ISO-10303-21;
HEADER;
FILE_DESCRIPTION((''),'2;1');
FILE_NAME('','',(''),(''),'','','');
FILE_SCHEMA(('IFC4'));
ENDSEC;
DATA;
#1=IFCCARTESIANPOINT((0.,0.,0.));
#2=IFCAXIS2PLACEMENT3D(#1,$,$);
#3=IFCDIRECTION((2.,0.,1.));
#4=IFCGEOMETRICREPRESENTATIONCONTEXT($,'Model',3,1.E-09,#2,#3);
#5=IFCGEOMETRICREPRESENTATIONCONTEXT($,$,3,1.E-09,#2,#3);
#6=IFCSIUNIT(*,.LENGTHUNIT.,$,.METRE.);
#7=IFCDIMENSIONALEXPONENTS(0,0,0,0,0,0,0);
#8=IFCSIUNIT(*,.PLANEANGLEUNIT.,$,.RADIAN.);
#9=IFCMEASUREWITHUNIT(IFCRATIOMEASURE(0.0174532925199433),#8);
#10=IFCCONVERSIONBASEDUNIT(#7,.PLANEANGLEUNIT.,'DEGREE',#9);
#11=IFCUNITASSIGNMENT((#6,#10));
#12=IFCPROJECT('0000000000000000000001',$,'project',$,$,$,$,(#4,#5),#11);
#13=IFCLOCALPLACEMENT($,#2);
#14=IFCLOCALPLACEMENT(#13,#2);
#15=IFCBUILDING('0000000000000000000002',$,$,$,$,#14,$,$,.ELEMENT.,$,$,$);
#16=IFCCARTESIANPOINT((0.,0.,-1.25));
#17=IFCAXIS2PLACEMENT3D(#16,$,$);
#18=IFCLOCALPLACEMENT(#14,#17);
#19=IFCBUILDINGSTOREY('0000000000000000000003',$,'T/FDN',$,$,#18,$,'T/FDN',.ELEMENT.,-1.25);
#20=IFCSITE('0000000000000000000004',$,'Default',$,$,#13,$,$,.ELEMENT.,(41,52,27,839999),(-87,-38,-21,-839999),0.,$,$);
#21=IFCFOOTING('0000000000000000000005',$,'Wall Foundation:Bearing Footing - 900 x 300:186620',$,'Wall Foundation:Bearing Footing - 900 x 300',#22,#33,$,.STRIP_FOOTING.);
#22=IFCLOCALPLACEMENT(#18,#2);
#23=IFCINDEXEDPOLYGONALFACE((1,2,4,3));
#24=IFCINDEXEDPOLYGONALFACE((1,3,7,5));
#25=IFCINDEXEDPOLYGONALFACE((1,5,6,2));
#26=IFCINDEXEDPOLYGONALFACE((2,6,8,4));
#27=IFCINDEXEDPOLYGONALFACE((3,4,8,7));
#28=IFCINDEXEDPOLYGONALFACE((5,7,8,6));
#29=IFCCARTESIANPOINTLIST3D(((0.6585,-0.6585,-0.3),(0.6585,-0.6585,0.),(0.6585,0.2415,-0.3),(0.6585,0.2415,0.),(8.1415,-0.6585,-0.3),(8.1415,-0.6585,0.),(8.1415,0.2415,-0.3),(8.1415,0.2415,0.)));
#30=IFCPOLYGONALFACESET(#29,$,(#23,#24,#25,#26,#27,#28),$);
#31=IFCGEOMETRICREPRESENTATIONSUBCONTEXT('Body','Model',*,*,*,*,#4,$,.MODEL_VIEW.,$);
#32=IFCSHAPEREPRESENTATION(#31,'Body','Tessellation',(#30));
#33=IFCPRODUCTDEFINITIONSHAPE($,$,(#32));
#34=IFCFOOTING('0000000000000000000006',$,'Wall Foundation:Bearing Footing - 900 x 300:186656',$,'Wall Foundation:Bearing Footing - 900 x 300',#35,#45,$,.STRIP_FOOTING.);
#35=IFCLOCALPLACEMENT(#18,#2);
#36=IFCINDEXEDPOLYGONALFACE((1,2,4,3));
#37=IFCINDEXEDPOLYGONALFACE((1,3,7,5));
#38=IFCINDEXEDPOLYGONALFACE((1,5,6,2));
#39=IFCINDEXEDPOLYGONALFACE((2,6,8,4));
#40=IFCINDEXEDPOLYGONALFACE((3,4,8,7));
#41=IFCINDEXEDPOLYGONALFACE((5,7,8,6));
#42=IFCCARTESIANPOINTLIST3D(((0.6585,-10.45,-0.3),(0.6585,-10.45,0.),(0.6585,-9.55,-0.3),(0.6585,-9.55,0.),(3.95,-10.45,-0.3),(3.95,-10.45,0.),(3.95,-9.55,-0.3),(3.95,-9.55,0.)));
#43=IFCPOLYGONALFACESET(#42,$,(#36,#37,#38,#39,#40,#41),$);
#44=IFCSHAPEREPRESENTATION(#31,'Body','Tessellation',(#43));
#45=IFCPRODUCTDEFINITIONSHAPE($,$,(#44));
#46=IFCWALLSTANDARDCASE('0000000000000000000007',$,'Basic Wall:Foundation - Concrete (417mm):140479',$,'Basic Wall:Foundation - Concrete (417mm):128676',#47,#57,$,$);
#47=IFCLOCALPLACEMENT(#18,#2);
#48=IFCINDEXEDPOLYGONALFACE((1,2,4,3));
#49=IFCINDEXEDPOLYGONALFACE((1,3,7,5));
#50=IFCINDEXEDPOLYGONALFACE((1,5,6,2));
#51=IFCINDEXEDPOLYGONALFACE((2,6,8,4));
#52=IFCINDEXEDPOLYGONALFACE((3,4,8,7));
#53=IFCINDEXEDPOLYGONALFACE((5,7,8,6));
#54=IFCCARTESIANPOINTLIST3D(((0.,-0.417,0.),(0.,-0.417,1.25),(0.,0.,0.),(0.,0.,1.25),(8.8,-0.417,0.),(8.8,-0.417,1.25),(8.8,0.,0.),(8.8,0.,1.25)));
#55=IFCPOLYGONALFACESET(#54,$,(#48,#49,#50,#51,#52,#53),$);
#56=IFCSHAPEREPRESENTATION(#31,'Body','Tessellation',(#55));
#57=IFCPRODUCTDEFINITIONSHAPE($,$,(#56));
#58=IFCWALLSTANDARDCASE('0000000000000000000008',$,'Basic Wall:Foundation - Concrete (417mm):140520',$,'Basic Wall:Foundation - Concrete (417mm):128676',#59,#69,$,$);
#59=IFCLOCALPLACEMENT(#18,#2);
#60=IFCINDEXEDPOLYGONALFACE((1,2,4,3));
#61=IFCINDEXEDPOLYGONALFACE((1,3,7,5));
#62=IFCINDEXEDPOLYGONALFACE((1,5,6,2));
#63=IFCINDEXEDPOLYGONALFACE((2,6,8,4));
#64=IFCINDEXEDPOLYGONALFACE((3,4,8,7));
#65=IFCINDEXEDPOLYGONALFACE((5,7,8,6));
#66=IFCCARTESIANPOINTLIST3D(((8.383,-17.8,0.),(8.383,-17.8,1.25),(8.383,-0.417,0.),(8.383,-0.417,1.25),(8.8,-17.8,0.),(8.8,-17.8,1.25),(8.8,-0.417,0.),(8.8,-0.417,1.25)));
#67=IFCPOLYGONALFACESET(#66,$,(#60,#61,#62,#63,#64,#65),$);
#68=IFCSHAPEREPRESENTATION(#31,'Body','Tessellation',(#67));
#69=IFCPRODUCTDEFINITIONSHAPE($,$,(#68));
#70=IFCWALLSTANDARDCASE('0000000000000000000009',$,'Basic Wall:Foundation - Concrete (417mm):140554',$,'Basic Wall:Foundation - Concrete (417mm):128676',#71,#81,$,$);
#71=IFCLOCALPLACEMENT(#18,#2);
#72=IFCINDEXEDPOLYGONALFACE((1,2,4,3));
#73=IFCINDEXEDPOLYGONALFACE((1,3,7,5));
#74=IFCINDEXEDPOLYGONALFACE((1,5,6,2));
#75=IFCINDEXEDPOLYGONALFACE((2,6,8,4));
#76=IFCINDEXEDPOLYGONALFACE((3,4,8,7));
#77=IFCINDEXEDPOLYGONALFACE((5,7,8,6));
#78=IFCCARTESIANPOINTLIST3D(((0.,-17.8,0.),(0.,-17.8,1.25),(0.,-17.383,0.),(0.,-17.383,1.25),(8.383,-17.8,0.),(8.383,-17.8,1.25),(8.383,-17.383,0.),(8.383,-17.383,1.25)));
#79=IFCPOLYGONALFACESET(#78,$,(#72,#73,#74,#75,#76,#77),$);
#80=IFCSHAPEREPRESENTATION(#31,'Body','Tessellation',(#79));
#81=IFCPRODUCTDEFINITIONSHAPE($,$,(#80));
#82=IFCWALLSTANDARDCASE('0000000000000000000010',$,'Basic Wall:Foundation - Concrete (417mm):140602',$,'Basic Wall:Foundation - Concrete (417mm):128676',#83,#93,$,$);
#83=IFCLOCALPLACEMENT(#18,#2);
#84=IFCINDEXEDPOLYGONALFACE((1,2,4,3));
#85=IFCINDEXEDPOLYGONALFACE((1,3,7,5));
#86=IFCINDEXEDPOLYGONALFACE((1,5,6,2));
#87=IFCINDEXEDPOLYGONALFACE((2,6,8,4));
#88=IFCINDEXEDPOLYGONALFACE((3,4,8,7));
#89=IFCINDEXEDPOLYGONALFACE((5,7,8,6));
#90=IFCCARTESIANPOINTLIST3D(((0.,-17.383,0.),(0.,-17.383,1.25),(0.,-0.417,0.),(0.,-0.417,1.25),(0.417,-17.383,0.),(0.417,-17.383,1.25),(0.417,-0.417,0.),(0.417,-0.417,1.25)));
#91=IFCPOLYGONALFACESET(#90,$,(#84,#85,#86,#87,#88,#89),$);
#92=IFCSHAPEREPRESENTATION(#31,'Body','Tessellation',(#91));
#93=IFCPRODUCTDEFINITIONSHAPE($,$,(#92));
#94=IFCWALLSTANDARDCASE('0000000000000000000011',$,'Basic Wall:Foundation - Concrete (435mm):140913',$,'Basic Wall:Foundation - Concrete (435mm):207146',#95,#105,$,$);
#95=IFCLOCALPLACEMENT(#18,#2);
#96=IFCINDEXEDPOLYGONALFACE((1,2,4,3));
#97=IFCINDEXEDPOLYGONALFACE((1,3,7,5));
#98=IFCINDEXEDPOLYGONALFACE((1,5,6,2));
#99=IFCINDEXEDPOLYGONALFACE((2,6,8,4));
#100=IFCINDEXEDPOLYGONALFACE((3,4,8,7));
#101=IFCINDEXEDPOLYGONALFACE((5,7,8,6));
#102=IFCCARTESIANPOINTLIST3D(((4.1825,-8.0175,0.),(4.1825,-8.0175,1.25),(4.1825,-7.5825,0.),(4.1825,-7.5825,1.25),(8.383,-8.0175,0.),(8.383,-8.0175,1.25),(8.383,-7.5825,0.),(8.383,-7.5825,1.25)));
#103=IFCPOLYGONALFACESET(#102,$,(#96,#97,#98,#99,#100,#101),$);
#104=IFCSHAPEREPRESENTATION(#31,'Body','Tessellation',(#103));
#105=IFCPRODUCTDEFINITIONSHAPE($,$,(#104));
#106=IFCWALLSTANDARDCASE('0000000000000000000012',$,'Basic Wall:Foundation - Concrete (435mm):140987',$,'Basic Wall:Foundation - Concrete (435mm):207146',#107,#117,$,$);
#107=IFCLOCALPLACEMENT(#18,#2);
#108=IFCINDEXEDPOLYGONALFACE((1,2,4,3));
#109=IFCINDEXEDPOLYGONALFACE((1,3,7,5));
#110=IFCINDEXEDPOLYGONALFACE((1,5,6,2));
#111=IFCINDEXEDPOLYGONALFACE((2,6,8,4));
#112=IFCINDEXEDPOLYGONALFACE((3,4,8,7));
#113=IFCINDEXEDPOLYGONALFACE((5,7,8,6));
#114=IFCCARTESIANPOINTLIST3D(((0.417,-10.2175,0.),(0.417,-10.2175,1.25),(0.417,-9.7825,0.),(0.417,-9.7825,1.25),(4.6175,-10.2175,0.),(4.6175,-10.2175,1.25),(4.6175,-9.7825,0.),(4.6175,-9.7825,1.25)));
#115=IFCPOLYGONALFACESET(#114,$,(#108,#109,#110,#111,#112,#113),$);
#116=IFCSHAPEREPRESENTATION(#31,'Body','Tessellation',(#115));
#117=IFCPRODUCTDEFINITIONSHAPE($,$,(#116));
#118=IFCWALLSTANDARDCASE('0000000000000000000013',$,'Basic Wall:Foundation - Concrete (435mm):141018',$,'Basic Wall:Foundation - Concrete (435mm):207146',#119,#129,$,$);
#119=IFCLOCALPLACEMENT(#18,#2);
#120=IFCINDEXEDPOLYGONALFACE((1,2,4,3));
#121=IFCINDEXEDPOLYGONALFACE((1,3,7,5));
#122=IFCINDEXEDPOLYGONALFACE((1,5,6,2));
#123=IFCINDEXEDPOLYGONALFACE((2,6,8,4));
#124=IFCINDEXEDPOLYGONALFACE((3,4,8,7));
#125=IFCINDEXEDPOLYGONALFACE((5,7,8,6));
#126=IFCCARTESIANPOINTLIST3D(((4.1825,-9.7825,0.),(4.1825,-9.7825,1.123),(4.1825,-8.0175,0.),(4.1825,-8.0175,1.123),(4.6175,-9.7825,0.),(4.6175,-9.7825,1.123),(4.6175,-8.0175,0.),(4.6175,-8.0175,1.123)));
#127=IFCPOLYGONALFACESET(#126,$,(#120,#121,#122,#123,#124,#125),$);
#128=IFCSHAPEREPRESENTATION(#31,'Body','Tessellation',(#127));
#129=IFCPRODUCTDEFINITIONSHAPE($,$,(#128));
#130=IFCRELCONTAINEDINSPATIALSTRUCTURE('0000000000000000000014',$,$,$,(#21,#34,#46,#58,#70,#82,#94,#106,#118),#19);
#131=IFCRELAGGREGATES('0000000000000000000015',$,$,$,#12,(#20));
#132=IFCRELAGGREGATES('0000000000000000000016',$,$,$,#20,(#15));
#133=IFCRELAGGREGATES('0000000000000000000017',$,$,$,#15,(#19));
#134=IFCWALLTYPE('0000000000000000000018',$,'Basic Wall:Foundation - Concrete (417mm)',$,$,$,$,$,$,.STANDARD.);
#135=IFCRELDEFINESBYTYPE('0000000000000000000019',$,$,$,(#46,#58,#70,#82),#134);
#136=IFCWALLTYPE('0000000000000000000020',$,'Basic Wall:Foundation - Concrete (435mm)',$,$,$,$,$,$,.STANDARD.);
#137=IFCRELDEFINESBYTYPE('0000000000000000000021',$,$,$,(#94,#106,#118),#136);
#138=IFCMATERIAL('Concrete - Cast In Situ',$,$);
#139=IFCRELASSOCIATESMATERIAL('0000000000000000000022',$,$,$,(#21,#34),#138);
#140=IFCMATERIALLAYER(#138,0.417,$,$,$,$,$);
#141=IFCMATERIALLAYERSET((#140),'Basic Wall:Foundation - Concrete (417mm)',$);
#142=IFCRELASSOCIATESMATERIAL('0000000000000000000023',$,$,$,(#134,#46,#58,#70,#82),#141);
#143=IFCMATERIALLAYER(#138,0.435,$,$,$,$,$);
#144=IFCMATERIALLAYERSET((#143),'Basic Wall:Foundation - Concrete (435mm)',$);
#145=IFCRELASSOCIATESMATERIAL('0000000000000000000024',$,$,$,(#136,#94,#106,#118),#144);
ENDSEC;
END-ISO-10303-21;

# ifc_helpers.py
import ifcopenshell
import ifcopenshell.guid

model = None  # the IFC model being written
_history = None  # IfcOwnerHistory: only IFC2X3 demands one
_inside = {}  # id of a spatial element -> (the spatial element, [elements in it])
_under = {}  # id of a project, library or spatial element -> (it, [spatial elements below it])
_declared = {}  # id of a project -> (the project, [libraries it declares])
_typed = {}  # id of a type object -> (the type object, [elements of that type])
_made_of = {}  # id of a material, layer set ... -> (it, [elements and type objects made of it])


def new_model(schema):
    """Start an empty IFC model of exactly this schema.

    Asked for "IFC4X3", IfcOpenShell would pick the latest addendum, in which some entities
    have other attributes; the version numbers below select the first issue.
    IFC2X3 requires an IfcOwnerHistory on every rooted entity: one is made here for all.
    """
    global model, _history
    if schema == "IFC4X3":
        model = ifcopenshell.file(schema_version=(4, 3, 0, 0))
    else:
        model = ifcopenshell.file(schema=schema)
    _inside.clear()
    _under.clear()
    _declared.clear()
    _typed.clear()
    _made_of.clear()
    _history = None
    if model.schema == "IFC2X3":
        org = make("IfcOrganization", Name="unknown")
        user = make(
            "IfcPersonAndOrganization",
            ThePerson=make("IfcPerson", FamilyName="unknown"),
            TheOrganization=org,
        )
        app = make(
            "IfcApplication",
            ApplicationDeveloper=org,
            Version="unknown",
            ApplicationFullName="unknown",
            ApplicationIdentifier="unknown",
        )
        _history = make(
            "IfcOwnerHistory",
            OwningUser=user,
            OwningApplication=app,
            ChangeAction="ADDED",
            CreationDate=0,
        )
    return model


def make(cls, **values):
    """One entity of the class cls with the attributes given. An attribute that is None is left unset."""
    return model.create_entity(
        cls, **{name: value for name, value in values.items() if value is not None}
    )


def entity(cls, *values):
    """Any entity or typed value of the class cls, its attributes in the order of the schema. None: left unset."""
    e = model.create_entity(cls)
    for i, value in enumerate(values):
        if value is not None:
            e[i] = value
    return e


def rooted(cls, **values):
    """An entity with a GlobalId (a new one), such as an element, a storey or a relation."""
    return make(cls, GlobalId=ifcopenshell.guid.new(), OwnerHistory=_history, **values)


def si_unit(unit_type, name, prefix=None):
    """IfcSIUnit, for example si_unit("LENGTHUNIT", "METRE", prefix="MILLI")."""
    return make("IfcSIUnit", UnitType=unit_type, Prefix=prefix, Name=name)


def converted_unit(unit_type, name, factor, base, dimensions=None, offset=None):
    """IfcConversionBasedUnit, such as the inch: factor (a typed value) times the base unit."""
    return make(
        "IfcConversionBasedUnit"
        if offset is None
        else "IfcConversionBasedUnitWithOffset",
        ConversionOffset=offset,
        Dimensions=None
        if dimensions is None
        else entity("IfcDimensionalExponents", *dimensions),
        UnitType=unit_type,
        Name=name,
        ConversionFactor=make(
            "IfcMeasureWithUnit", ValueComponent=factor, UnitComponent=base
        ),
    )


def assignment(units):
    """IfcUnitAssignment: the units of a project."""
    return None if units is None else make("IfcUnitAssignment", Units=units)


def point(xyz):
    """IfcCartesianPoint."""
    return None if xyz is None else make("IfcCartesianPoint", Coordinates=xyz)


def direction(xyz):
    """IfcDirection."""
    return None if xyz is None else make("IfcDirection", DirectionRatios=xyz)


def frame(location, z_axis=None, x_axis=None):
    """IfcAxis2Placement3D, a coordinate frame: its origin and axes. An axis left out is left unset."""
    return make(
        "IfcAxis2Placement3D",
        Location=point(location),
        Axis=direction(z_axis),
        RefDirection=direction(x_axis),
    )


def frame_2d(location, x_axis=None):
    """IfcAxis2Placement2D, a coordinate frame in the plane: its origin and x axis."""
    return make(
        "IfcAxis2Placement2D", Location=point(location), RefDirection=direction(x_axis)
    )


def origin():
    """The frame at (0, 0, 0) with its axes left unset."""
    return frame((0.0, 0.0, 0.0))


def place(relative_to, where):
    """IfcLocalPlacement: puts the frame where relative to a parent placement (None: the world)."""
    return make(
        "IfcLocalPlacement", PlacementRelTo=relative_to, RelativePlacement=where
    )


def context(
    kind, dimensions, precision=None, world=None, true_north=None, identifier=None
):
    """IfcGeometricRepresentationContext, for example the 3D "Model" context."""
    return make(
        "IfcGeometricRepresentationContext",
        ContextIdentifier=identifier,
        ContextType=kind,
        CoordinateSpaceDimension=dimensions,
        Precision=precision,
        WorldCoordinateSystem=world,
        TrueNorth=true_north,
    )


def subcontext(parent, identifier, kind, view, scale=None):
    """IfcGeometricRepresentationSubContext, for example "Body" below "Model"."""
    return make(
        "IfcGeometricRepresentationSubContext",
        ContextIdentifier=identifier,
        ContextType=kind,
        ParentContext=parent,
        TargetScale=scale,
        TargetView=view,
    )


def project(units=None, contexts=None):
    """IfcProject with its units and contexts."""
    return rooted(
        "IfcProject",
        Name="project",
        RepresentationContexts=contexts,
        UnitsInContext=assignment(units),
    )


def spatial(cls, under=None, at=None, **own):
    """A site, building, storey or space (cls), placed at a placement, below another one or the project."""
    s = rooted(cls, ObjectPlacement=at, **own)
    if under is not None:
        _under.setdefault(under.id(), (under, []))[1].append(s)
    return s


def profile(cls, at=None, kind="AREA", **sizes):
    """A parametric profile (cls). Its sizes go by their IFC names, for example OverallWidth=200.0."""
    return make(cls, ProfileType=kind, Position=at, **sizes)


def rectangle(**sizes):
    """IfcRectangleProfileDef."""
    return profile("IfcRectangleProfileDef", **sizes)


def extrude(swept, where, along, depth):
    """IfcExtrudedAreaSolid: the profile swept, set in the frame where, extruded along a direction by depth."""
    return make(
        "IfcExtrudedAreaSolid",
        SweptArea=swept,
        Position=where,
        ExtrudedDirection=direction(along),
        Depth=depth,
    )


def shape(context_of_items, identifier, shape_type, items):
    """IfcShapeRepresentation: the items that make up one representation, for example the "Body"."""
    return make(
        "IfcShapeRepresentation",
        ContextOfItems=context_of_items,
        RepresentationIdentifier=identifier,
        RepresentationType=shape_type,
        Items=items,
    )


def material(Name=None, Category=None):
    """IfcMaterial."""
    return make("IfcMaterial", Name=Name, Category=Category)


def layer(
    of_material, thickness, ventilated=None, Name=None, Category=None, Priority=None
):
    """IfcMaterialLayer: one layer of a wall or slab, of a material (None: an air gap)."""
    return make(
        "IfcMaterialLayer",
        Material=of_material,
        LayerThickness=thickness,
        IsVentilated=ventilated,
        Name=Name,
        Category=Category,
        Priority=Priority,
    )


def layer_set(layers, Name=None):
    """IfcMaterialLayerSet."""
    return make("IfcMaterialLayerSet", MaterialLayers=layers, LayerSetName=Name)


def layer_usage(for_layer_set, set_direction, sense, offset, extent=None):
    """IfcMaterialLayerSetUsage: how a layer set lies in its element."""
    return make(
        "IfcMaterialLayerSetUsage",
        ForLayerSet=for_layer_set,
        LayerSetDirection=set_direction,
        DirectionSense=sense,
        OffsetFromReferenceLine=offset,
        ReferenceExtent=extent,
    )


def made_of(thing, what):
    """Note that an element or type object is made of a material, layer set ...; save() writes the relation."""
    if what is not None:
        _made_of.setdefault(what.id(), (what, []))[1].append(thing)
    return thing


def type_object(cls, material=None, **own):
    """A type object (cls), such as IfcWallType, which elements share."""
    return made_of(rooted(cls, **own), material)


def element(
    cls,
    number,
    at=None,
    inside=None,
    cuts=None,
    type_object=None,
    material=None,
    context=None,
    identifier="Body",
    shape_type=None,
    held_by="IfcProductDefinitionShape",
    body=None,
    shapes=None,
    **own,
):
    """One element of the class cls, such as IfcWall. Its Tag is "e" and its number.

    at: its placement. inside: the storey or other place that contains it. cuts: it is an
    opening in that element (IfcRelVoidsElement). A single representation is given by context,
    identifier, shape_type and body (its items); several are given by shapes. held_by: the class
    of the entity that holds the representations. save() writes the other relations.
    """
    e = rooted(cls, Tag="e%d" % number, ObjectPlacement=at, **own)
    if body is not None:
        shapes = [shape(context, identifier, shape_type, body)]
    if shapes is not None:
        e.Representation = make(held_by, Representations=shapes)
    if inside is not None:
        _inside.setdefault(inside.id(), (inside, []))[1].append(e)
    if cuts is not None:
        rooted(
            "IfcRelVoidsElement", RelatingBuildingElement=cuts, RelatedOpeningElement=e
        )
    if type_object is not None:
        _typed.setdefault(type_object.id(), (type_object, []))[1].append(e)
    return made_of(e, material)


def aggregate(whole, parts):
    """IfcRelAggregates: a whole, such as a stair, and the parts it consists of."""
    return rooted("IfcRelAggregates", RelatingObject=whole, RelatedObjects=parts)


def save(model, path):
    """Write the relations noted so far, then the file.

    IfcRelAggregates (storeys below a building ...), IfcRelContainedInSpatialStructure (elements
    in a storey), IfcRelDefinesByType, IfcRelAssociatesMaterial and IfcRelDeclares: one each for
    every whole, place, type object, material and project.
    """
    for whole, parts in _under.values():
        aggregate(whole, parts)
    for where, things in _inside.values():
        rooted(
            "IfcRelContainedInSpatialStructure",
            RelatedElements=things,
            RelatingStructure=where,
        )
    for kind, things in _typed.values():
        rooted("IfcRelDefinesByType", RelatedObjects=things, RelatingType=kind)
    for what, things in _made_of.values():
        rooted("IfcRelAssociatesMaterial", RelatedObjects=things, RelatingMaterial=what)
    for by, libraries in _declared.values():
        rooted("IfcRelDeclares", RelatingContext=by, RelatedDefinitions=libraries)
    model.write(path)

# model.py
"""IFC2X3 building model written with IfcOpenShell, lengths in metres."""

from ifc_helpers import new_model, entity, si_unit, converted_unit, direction, frame, frame_2d, origin, place, context, subcontext, project, spatial, rectangle, extrude, material, layer, layer_set, layer_usage, type_object, element, save


model = new_model("IFC2X3")

# Units and contexts
model_context = context("Model", 3, precision=1e-09, world=origin(), true_north=direction((2.0, 0.0, 1.0)))
context_of_model = context(None, 3, precision=1e-09, world=origin(), true_north=direction((2.0, 0.0, 1.0)))
body_context = subcontext(model_context, "Body", "Model", "MODEL_VIEW")
ifc_project = project(units=[si_unit("LENGTHUNIT", "METRE"), converted_unit("PLANEANGLEUNIT", "DEGREE", entity("IfcRatioMeasure", 0.0174532925199433), si_unit("PLANEANGLEUNIT", "RADIAN"), dimensions=[0, 0, 0, 0, 0, 0, 0])], contexts=[model_context, context_of_model])

# Site, building, storey
site_placement = place(None, origin())
site = spatial("IfcSite", under=ifc_project, at=site_placement, Name="Default", CompositionType="ELEMENT", RefLatitude=(41, 52, 27, 839999), RefLongitude=(-87, -38, -21, -839999), RefElevation=0.0)
building_placement = place(site_placement, origin())
building = spatial("IfcBuilding", under=site, at=building_placement, CompositionType="ELEMENT")
storey_placement = place(building_placement, frame((0.0, 0.0, -1.25)))
storey = spatial("IfcBuildingStorey", under=building, at=storey_placement, Name="T/FDN", LongName="T/FDN", CompositionType="ELEMENT", Elevation=-1.25)

# Footings
ifc_material = material(Name="Concrete - Cast In Situ")
footing_1_placement = place(storey_placement, origin())
element("IfcFooting", 1, at=footing_1_placement, inside=storey, material=ifc_material, Name="Wall Foundation:Bearing Footing - 900 x 300:186620", ObjectType="Wall Foundation:Bearing Footing - 900 x 300", PredefinedType="STRIP_FOOTING", context=body_context, shape_type="SweptSolid", body=[
    extrude(rectangle(XDim=7.483, YDim=0.9, at=frame_2d((0.0, 0.0), x_axis=(1.0, 0.0))), frame((4.4, -0.2085, -0.3), z_axis=(0.0, 0.0, 1.0), x_axis=(-1.0, 0.0, 0.0)), (0.0, 0.0, 1.0), 0.3),
])
footing_2_placement = place(storey_placement, origin())
element("IfcFooting", 2, at=footing_2_placement, inside=storey, material=ifc_material, Name="Wall Foundation:Bearing Footing - 900 x 300:186656", ObjectType="Wall Foundation:Bearing Footing - 900 x 300", PredefinedType="STRIP_FOOTING", context=body_context, shape_type="SweptSolid", body=[
    extrude(rectangle(XDim=3.2915, YDim=0.9, at=frame_2d((0.0, 0.0), x_axis=(1.0, 0.0))), frame((2.3043, -10.0, -0.3)), (0.0, 0.0, 1.0), 0.3),
])

# Walls
ifc_layer_1 = layer(ifc_material, 0.417)
ifc_layer_set_1 = layer_set([ifc_layer_1], Name="Basic Wall:Foundation - Concrete (417mm)")
ifc_layer_usage_1 = layer_usage(ifc_layer_set_1, "AXIS2", "NEGATIVE", 0.2085)
wall_type_1 = type_object("IfcWallType", Name="Basic Wall:Foundation - Concrete (417mm)", PredefinedType="STANDARD", material=ifc_layer_set_1)
wall_1_placement = place(storey_placement, frame((0.0, -0.2085, 0.0)))
element("IfcWallStandardCase", 3, at=wall_1_placement, inside=storey, type_object=wall_type_1, material=ifc_layer_usage_1, Name="Basic Wall:Foundation - Concrete (417mm):140479", ObjectType="Basic Wall:Foundation - Concrete (417mm):128676", context=body_context, shape_type="SweptSolid", body=[
    extrude(rectangle(XDim=8.8, YDim=0.417, at=frame_2d((4.4, 0.0), x_axis=(-1.0, 0.0))), origin(), (0.0, 0.0, 1.0), 1.25),
])
ifc_layer_usage_2 = layer_usage(ifc_layer_set_1, "AXIS2", "NEGATIVE", 0.2085)
wall_2_placement = place(storey_placement, frame((8.5915, -0.417, 0.0), z_axis=(0.0, 0.0, 1.0), x_axis=(0.0, -1.0, 0.0)))
element("IfcWallStandardCase", 4, at=wall_2_placement, inside=storey, type_object=wall_type_1, material=ifc_layer_usage_2, Name="Basic Wall:Foundation - Concrete (417mm):140520", ObjectType="Basic Wall:Foundation - Concrete (417mm):128676", context=body_context, shape_type="SweptSolid", body=[
    extrude(rectangle(XDim=17.383, YDim=0.417, at=frame_2d((8.6915, 0.0), x_axis=(-1.0, 0.0))), origin(), (0.0, 0.0, 1.0), 1.25),
])
ifc_layer_usage_3 = layer_usage(ifc_layer_set_1, "AXIS2", "NEGATIVE", 0.2085)
wall_3_placement = place(storey_placement, frame((8.383, -17.5915, 0.0), z_axis=(0.0, 0.0, 1.0), x_axis=(-1.0, 0.0, 0.0)))
element("IfcWallStandardCase", 5, at=wall_3_placement, inside=storey, type_object=wall_type_1, material=ifc_layer_usage_3, Name="Basic Wall:Foundation - Concrete (417mm):140554", ObjectType="Basic Wall:Foundation - Concrete (417mm):128676", context=body_context, shape_type="SweptSolid", body=[
    extrude(rectangle(XDim=8.383, YDim=0.417, at=frame_2d((4.1915, 0.0), x_axis=(-1.0, 0.0))), origin(), (0.0, 0.0, 1.0), 1.25),
])
ifc_layer_usage_4 = layer_usage(ifc_layer_set_1, "AXIS2", "NEGATIVE", 0.2085)
wall_4_placement = place(storey_placement, frame((0.2085, -17.383, 0.0), z_axis=(0.0, 0.0, 1.0), x_axis=(0.0, 1.0, 0.0)))
element("IfcWallStandardCase", 6, at=wall_4_placement, inside=storey, type_object=wall_type_1, material=ifc_layer_usage_4, Name="Basic Wall:Foundation - Concrete (417mm):140602", ObjectType="Basic Wall:Foundation - Concrete (417mm):128676", context=body_context, shape_type="SweptSolid", body=[
    extrude(rectangle(XDim=16.966, YDim=0.417, at=frame_2d((8.483, 0.0), x_axis=(-1.0, 0.0))), origin(), (0.0, 0.0, 1.0), 1.25),
])
ifc_layer_2 = layer(ifc_material, 0.435)
ifc_layer_set_2 = layer_set([ifc_layer_2], Name="Basic Wall:Foundation - Concrete (435mm)")
ifc_layer_usage_5 = layer_usage(ifc_layer_set_2, "AXIS2", "NEGATIVE", 0.2175)
wall_type_2 = type_object("IfcWallType", Name="Basic Wall:Foundation - Concrete (435mm)", PredefinedType="STANDARD", material=ifc_layer_set_2)
wall_5_placement = place(storey_placement, frame((8.383, -7.8, 0.0), z_axis=(0.0, 0.0, 1.0), x_axis=(-1.0, 0.0, 0.0)))
element("IfcWallStandardCase", 7, at=wall_5_placement, inside=storey, type_object=wall_type_2, material=ifc_layer_usage_5, Name="Basic Wall:Foundation - Concrete (435mm):140913", ObjectType="Basic Wall:Foundation - Concrete (435mm):207146", context=body_context, shape_type="SweptSolid", body=[
    extrude(rectangle(XDim=4.2005, YDim=0.435, at=frame_2d((2.1002, 0.0), x_axis=(-1.0, 0.0))), origin(), (0.0, 0.0, 1.0), 1.25),
])
ifc_layer_usage_6 = layer_usage(ifc_layer_set_2, "AXIS2", "NEGATIVE", 0.2175)
wall_6_placement = place(storey_placement, frame((0.417, -10.0, 0.0)))
element("IfcWallStandardCase", 8, at=wall_6_placement, inside=storey, type_object=wall_type_2, material=ifc_layer_usage_6, Name="Basic Wall:Foundation - Concrete (435mm):140987", ObjectType="Basic Wall:Foundation - Concrete (435mm):207146", context=body_context, shape_type="SweptSolid", body=[
    extrude(rectangle(XDim=4.2005, YDim=0.435, at=frame_2d((2.1002, 0.0), x_axis=(-1.0, 0.0))), origin(), (0.0, 0.0, 1.0), 1.25),
])
ifc_layer_usage_7 = layer_usage(ifc_layer_set_2, "AXIS2", "NEGATIVE", 0.2175)
wall_7_placement = place(storey_placement, frame((4.4, -9.7825, 0.0), z_axis=(0.0, 0.0, 1.0), x_axis=(0.0, 1.0, 0.0)))
element("IfcWallStandardCase", 9, at=wall_7_placement, inside=storey, type_object=wall_type_2, material=ifc_layer_usage_7, Name="Basic Wall:Foundation - Concrete (435mm):141018", ObjectType="Basic Wall:Foundation - Concrete (435mm):207146", context=body_context, shape_type="SweptSolid", body=[
    extrude(rectangle(XDim=1.765, YDim=0.435, at=frame_2d((0.8825, 0.0), x_axis=(-1.0, 0.0))), origin(), (0.0, 0.0, 1.0), 1.123),
])

save(model, "model.ifc")
